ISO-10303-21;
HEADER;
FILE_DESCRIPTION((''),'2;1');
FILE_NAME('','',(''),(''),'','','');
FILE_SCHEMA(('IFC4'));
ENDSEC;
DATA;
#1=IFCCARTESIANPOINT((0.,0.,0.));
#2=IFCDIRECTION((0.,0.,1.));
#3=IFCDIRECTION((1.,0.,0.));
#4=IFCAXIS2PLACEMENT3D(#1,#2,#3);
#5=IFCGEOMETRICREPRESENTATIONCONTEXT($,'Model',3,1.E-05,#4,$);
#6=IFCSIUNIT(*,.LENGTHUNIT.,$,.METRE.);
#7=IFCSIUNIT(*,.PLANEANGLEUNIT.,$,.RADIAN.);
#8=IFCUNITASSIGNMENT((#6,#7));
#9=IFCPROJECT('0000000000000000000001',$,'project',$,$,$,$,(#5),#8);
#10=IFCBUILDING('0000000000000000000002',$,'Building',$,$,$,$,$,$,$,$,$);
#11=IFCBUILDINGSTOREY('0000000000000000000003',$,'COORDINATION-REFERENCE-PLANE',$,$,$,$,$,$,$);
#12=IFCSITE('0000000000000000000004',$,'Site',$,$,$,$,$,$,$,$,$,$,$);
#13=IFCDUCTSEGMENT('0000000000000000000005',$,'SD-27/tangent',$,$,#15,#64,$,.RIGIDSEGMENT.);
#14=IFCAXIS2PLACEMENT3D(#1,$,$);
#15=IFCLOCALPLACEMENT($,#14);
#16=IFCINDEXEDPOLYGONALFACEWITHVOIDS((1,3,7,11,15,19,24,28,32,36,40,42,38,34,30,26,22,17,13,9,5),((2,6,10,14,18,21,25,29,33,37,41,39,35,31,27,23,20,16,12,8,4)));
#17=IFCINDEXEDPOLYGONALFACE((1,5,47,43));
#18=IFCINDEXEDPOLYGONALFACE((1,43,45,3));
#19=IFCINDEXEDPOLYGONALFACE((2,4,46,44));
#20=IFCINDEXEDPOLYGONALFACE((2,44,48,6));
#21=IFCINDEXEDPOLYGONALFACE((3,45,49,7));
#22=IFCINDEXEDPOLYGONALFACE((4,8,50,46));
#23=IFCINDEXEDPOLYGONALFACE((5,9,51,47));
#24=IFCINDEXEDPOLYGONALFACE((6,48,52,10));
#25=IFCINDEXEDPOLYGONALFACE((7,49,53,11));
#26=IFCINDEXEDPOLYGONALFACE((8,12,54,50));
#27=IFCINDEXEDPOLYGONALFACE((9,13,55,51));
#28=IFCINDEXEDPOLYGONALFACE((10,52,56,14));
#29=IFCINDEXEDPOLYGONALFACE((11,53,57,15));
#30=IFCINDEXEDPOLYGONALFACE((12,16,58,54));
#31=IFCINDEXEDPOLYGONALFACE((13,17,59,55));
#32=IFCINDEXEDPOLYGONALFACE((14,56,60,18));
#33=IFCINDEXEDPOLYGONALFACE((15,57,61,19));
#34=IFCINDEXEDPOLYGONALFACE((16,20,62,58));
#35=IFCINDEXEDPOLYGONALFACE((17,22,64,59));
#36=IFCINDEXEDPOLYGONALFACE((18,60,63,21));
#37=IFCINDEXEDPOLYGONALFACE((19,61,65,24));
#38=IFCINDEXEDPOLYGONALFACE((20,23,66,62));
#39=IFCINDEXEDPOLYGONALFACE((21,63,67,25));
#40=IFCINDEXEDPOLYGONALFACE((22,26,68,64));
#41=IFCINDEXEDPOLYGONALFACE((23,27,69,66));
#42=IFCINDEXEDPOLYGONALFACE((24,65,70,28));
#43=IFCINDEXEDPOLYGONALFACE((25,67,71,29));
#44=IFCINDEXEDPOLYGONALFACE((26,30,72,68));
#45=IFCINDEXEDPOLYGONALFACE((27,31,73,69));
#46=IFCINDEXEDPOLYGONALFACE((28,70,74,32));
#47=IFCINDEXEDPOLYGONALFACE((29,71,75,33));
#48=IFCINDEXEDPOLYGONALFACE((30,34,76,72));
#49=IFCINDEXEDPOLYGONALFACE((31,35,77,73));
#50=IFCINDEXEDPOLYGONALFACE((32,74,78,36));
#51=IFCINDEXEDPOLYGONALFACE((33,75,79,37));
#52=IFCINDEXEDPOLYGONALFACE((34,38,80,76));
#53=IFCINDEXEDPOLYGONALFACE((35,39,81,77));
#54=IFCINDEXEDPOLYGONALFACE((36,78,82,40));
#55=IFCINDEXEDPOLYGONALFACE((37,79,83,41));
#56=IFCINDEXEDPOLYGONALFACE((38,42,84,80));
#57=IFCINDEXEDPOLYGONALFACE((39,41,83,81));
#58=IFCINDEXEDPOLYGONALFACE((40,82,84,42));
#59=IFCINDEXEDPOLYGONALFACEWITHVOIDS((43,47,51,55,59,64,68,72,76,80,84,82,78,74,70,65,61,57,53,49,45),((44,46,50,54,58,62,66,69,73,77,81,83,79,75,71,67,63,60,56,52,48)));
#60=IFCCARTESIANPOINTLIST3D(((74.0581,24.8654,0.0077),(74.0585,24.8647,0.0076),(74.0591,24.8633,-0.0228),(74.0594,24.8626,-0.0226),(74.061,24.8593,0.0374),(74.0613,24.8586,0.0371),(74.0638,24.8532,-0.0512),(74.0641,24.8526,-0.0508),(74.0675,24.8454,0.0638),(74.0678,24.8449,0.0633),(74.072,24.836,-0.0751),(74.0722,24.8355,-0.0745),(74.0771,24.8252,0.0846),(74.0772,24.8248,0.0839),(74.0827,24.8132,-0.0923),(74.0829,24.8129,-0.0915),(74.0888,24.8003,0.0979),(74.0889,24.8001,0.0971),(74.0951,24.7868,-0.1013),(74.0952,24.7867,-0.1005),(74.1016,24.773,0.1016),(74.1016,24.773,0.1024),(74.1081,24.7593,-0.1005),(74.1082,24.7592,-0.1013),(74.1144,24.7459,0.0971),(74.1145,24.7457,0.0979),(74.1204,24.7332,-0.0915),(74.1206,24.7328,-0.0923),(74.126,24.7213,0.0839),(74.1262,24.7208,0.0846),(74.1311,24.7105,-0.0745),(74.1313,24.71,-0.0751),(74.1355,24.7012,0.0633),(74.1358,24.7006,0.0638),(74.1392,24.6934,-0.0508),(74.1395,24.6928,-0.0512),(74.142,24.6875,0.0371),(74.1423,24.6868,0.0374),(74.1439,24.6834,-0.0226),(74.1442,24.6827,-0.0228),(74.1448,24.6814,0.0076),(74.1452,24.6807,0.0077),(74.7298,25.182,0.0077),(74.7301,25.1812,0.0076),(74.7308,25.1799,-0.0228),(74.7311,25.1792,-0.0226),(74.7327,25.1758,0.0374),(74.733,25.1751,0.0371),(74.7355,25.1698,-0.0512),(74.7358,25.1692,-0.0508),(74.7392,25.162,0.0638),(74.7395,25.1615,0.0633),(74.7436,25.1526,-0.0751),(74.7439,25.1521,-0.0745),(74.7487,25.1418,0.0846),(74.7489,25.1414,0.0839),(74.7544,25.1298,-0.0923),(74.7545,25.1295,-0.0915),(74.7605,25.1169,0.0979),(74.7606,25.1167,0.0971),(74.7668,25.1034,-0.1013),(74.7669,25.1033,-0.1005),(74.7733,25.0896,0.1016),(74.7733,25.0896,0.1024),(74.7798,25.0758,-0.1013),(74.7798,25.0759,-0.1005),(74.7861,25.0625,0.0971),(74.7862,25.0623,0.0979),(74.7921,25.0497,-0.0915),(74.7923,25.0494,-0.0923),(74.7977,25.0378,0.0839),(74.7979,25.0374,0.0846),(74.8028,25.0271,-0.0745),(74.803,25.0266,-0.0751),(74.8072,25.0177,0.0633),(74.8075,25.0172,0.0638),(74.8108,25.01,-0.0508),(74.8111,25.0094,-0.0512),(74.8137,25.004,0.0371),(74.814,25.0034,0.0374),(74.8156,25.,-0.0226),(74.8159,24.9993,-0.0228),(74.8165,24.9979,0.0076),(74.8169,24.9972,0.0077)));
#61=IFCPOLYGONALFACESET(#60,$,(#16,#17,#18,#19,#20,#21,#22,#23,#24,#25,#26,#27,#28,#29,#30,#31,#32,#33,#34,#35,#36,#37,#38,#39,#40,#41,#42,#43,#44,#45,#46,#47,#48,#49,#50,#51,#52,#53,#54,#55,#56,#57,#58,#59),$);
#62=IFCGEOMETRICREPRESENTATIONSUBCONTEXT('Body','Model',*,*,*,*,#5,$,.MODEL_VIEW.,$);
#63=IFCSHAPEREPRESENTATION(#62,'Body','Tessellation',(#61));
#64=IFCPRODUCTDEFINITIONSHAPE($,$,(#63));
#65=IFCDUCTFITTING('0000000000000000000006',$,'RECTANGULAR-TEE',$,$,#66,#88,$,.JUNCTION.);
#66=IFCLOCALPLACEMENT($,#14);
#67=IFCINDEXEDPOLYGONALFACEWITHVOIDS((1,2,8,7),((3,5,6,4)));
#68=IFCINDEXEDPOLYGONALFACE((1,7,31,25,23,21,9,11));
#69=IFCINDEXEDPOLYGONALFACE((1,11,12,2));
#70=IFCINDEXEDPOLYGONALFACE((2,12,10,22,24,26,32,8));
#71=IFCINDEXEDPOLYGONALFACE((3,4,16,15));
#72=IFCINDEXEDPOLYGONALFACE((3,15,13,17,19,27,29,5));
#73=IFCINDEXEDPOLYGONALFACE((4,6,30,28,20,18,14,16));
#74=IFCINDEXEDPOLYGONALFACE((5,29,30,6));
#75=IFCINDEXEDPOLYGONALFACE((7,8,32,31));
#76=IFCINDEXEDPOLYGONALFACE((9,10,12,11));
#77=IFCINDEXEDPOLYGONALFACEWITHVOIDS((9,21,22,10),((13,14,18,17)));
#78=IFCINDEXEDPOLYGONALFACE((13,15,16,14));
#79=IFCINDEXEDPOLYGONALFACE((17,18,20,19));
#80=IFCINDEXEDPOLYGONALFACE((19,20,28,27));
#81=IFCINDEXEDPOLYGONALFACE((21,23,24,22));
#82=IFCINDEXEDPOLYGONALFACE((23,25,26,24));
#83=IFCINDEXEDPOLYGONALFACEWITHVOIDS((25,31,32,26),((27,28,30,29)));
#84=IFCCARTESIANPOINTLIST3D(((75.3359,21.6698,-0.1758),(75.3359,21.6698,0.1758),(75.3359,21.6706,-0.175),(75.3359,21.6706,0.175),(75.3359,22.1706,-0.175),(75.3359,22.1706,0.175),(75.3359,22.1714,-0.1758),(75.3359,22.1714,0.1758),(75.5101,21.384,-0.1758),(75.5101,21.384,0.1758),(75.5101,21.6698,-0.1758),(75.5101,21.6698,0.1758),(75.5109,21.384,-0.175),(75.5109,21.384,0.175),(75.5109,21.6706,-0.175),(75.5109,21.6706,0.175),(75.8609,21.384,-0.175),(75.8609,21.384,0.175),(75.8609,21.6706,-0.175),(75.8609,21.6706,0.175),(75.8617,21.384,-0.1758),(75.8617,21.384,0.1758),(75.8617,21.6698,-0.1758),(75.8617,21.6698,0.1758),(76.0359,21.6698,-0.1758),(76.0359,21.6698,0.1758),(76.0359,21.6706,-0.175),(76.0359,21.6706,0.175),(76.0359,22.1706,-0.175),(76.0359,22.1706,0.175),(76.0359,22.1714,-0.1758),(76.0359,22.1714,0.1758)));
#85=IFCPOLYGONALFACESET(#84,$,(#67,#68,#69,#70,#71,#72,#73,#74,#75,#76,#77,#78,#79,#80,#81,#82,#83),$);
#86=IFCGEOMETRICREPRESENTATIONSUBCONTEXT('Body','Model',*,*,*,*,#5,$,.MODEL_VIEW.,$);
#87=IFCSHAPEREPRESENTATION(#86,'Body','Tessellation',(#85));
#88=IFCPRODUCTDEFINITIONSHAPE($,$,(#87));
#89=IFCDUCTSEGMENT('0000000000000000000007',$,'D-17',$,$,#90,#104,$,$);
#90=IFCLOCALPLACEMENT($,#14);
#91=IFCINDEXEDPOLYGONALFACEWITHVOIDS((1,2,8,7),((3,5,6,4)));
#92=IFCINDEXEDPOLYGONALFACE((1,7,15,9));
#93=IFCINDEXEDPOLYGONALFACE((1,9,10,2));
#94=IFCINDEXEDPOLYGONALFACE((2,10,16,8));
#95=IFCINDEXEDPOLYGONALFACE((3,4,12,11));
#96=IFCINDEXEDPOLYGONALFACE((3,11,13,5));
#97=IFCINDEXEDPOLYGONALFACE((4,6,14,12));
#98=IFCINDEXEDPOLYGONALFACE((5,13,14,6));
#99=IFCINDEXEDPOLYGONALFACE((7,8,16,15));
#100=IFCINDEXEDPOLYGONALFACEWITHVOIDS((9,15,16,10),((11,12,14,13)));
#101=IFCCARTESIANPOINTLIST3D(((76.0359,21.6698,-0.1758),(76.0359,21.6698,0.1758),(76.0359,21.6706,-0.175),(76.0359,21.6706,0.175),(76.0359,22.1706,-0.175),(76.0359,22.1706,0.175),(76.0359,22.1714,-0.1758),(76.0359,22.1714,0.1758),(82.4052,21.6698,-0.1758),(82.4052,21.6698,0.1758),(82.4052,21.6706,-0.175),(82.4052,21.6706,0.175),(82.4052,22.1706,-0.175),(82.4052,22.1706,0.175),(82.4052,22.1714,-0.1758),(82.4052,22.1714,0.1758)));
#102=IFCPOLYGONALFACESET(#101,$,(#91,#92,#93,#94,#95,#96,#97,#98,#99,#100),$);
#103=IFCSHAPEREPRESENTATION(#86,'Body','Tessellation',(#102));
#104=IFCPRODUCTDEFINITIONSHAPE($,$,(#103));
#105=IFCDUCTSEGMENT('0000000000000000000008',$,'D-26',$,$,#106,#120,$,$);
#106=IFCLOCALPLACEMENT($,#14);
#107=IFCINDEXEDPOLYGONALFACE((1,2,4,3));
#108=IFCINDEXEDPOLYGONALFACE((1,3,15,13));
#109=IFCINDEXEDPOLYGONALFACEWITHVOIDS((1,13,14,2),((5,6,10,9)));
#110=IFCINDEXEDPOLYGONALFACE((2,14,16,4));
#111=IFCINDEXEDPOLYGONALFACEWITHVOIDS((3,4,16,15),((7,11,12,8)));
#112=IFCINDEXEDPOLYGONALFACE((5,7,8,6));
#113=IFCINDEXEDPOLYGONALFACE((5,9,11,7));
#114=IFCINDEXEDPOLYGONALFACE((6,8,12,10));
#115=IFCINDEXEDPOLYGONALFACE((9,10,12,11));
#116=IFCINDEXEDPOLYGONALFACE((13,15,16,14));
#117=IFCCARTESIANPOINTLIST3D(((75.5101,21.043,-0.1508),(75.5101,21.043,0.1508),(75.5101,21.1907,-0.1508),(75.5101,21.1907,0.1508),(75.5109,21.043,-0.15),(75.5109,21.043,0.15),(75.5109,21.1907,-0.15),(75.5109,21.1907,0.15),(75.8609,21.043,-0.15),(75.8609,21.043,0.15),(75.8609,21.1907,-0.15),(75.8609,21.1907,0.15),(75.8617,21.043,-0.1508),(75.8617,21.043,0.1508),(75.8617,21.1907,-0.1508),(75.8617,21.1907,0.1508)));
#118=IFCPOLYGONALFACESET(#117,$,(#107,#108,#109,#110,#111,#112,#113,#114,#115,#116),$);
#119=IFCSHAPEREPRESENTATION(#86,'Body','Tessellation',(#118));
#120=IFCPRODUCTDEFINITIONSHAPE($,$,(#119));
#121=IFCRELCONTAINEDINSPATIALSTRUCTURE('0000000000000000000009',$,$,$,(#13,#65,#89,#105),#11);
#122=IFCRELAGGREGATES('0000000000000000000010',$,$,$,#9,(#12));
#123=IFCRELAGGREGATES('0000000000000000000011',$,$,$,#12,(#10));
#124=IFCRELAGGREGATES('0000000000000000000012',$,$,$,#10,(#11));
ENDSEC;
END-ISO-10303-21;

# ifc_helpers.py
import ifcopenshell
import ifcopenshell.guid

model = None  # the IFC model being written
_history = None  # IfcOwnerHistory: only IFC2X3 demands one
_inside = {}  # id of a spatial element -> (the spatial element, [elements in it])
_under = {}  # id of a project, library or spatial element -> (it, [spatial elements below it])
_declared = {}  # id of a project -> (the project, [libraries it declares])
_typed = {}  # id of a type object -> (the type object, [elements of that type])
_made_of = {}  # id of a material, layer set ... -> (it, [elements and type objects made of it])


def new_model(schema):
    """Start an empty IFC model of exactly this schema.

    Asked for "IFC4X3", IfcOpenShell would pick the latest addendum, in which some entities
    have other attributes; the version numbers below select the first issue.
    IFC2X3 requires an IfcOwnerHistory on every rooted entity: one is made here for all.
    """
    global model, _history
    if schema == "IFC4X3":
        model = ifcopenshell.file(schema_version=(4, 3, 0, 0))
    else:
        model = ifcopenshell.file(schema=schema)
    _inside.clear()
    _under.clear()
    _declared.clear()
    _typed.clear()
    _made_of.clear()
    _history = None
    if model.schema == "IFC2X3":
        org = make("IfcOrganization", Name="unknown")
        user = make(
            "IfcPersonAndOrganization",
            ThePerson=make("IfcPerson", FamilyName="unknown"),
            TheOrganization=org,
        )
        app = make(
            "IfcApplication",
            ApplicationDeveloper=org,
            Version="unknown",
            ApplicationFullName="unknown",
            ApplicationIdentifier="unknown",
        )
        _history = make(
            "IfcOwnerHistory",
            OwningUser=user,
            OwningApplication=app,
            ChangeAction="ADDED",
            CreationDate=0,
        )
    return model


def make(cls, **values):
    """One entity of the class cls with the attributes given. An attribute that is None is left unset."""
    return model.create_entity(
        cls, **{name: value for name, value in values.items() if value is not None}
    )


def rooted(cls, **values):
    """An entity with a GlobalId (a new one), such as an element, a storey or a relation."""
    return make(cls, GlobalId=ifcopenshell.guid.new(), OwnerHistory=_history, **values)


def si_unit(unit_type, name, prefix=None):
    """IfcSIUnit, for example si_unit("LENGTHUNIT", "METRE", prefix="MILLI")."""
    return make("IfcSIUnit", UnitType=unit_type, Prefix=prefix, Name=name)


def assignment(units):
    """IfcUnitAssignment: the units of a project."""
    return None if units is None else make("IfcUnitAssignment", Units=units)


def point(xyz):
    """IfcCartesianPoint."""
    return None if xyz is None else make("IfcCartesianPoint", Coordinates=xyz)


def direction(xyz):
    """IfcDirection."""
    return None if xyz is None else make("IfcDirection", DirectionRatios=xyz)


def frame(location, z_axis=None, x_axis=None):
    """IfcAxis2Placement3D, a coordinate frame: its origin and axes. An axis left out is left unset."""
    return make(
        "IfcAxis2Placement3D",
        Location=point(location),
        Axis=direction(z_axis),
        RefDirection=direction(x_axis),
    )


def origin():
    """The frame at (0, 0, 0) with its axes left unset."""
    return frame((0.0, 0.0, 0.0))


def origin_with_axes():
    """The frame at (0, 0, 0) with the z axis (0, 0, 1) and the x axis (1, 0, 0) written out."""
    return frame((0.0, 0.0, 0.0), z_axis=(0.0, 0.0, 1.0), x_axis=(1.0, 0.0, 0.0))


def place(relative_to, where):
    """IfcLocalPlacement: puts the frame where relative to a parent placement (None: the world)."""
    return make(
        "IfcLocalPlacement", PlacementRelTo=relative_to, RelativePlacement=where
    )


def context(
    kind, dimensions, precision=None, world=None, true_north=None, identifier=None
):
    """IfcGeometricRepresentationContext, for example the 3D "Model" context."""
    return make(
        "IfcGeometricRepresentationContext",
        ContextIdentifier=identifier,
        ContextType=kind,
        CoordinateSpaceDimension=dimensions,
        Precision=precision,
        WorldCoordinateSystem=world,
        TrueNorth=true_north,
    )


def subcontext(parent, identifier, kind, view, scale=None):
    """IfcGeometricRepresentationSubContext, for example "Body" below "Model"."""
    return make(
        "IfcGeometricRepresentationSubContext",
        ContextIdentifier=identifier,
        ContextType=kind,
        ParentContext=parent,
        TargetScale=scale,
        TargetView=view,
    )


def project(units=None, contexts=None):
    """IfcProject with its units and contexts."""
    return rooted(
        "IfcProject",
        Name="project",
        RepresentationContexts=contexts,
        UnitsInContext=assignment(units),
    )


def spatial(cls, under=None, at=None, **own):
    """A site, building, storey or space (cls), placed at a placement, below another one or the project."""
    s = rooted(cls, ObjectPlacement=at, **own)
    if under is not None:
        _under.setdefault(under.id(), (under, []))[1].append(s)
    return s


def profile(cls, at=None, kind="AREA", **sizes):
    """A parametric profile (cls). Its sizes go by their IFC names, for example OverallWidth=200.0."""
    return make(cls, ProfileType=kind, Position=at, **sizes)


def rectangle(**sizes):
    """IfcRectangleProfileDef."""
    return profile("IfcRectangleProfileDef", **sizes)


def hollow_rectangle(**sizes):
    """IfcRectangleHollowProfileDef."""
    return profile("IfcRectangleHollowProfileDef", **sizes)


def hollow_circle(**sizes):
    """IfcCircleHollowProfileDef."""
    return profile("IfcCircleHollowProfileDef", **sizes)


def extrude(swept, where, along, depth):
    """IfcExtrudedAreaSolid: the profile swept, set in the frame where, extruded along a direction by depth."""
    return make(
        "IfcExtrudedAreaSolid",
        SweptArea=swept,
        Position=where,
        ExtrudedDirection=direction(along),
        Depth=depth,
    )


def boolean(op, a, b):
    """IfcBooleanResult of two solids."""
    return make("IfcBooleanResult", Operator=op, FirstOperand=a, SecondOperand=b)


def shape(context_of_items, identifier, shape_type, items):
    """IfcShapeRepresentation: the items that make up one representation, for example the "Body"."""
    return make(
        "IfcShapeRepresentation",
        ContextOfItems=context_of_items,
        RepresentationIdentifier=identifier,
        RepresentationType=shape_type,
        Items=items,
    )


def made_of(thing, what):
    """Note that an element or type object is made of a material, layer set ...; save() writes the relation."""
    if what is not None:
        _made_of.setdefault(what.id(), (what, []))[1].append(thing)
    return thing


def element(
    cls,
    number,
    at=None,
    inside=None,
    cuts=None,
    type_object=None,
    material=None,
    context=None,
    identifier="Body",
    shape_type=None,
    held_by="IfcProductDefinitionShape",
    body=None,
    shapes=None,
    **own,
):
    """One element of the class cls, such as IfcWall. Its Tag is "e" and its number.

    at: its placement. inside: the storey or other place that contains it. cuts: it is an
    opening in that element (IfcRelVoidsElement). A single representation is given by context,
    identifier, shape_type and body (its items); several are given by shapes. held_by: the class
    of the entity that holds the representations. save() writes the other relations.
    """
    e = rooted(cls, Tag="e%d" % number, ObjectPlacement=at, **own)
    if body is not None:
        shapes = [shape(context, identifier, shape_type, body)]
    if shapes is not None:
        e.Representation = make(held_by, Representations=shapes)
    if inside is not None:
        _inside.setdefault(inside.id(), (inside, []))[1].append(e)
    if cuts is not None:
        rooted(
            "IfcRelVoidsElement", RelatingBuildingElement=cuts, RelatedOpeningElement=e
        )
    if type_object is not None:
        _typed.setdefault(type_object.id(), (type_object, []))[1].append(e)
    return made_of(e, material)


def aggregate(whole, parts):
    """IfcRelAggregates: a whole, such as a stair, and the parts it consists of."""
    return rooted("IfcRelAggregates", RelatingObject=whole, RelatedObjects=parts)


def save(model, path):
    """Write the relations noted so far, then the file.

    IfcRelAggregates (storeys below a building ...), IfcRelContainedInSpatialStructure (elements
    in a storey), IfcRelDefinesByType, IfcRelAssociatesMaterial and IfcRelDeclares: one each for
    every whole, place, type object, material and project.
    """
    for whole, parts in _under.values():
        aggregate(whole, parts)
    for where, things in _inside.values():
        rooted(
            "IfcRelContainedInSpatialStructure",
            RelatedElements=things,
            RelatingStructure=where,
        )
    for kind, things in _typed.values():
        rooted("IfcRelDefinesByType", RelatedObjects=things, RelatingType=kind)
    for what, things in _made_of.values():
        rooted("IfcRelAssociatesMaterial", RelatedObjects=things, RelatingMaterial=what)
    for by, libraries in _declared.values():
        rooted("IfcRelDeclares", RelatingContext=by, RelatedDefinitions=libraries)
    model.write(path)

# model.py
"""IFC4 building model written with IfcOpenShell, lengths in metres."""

from ifc_helpers import new_model, si_unit, frame, origin, origin_with_axes, place, context, subcontext, project, spatial, rectangle, hollow_rectangle, hollow_circle, extrude, boolean, element, save


model = new_model("IFC4")

# Units and contexts
model_context_1 = context("Model", 3, precision=1e-05, world=origin_with_axes())
body_context_1 = subcontext(model_context_1, "Body", "Model", "MODEL_VIEW")
body_context_2 = subcontext(model_context_1, "Body", "Model", "MODEL_VIEW")
ifc_project = project(units=[si_unit("LENGTHUNIT", "METRE"), si_unit("PLANEANGLEUNIT", "RADIAN")], contexts=[model_context_1])

# Site, building, storey
site = spatial("IfcSite", under=ifc_project, Name="Site")
building = spatial("IfcBuilding", under=site, Name="Building")
storey = spatial("IfcBuildingStorey", under=building, Name="COORDINATION-REFERENCE-PLANE")

# Duct segment
duct_segment_1_placement = place(None, frame((74.7733, 25.0896, 0.0), z_axis=(-0.904569, -0.426327, 0.0), x_axis=(0.0, 0.0, 1.0)))
element("IfcDuctSegment", 1, at=duct_segment_1_placement, inside=storey, Name="SD-27/tangent", PredefinedType="RIGIDSEGMENT", context=body_context_1, shape_type="SweptSolid", body=[
    extrude(hollow_circle(Radius=0.1024, WallThickness=0.0008), origin_with_axes(), (0.0, 0.0, 1.0), 0.7425),
])

# Duct fitting
duct_fitting_1_placement = place(None, frame((75.6859, 21.9206, 0.0), z_axis=(-1.0, 0.0, 0.0), x_axis=(0.0, -1.0, 0.0)))
solid_1 = boolean("UNION", extrude(rectangle(XDim=0.5, YDim=0.35), frame((0.0, 0.0, -0.35), z_axis=(0.0, 0.0, 1.0), x_axis=(1.0, 0.0, 0.0)), (0.0, 0.0, 1.0), 0.7), extrude(rectangle(XDim=0.35, YDim=0.35), frame((0.0, 0.0, 0.0), z_axis=(1.0, 0.0, 0.0), x_axis=(0.0, 0.0, -1.0)), (0.0, 0.0, 1.0), 0.5366))
element("IfcDuctFitting", 2, at=duct_fitting_1_placement, inside=storey, Name="RECTANGULAR-TEE", PredefinedType="JUNCTION", context=body_context_2, shape_type="CSG", body=[
    boolean("DIFFERENCE", boolean("UNION", extrude(rectangle(XDim=0.5016, YDim=0.3516), frame((0.0, 0.0, -0.35), z_axis=(0.0, 0.0, 1.0), x_axis=(1.0, 0.0, 0.0)), (0.0, 0.0, 1.0), 0.7), extrude(rectangle(XDim=0.3516, YDim=0.3516), frame((0.0, 0.0, 0.0), z_axis=(1.0, 0.0, 0.0), x_axis=(0.0, 0.0, -1.0)), (0.0, 0.0, 1.0), 0.5366)), solid_1),
])

# Duct segments
duct_segment_2_placement = place(None, frame((76.0359, 21.9206, 0.0), z_axis=(1.0, 0.0, 0.0), x_axis=(0.0, 1.0, 0.0)))
element("IfcDuctSegment", 3, at=duct_segment_2_placement, inside=storey, Name="D-17", context=body_context_2, shape_type="SweptSolid", body=[
    extrude(hollow_rectangle(XDim=0.5016, YDim=0.3516, WallThickness=0.0008), origin(), (0.0, 0.0, 1.0), 6.3693),
])
duct_segment_3_placement = place(None, frame((75.6859, 21.043, 0.0), z_axis=(0.0, 1.0, 0.0), x_axis=(1.0, 0.0, 0.0)))
element("IfcDuctSegment", 4, at=duct_segment_3_placement, inside=storey, Name="D-26", context=body_context_2, shape_type="SweptSolid", body=[
    extrude(hollow_rectangle(XDim=0.3516, YDim=0.3016, WallThickness=0.0008), origin(), (0.0, 0.0, 1.0), 0.1477),
])

save(model, "model.ifc")
